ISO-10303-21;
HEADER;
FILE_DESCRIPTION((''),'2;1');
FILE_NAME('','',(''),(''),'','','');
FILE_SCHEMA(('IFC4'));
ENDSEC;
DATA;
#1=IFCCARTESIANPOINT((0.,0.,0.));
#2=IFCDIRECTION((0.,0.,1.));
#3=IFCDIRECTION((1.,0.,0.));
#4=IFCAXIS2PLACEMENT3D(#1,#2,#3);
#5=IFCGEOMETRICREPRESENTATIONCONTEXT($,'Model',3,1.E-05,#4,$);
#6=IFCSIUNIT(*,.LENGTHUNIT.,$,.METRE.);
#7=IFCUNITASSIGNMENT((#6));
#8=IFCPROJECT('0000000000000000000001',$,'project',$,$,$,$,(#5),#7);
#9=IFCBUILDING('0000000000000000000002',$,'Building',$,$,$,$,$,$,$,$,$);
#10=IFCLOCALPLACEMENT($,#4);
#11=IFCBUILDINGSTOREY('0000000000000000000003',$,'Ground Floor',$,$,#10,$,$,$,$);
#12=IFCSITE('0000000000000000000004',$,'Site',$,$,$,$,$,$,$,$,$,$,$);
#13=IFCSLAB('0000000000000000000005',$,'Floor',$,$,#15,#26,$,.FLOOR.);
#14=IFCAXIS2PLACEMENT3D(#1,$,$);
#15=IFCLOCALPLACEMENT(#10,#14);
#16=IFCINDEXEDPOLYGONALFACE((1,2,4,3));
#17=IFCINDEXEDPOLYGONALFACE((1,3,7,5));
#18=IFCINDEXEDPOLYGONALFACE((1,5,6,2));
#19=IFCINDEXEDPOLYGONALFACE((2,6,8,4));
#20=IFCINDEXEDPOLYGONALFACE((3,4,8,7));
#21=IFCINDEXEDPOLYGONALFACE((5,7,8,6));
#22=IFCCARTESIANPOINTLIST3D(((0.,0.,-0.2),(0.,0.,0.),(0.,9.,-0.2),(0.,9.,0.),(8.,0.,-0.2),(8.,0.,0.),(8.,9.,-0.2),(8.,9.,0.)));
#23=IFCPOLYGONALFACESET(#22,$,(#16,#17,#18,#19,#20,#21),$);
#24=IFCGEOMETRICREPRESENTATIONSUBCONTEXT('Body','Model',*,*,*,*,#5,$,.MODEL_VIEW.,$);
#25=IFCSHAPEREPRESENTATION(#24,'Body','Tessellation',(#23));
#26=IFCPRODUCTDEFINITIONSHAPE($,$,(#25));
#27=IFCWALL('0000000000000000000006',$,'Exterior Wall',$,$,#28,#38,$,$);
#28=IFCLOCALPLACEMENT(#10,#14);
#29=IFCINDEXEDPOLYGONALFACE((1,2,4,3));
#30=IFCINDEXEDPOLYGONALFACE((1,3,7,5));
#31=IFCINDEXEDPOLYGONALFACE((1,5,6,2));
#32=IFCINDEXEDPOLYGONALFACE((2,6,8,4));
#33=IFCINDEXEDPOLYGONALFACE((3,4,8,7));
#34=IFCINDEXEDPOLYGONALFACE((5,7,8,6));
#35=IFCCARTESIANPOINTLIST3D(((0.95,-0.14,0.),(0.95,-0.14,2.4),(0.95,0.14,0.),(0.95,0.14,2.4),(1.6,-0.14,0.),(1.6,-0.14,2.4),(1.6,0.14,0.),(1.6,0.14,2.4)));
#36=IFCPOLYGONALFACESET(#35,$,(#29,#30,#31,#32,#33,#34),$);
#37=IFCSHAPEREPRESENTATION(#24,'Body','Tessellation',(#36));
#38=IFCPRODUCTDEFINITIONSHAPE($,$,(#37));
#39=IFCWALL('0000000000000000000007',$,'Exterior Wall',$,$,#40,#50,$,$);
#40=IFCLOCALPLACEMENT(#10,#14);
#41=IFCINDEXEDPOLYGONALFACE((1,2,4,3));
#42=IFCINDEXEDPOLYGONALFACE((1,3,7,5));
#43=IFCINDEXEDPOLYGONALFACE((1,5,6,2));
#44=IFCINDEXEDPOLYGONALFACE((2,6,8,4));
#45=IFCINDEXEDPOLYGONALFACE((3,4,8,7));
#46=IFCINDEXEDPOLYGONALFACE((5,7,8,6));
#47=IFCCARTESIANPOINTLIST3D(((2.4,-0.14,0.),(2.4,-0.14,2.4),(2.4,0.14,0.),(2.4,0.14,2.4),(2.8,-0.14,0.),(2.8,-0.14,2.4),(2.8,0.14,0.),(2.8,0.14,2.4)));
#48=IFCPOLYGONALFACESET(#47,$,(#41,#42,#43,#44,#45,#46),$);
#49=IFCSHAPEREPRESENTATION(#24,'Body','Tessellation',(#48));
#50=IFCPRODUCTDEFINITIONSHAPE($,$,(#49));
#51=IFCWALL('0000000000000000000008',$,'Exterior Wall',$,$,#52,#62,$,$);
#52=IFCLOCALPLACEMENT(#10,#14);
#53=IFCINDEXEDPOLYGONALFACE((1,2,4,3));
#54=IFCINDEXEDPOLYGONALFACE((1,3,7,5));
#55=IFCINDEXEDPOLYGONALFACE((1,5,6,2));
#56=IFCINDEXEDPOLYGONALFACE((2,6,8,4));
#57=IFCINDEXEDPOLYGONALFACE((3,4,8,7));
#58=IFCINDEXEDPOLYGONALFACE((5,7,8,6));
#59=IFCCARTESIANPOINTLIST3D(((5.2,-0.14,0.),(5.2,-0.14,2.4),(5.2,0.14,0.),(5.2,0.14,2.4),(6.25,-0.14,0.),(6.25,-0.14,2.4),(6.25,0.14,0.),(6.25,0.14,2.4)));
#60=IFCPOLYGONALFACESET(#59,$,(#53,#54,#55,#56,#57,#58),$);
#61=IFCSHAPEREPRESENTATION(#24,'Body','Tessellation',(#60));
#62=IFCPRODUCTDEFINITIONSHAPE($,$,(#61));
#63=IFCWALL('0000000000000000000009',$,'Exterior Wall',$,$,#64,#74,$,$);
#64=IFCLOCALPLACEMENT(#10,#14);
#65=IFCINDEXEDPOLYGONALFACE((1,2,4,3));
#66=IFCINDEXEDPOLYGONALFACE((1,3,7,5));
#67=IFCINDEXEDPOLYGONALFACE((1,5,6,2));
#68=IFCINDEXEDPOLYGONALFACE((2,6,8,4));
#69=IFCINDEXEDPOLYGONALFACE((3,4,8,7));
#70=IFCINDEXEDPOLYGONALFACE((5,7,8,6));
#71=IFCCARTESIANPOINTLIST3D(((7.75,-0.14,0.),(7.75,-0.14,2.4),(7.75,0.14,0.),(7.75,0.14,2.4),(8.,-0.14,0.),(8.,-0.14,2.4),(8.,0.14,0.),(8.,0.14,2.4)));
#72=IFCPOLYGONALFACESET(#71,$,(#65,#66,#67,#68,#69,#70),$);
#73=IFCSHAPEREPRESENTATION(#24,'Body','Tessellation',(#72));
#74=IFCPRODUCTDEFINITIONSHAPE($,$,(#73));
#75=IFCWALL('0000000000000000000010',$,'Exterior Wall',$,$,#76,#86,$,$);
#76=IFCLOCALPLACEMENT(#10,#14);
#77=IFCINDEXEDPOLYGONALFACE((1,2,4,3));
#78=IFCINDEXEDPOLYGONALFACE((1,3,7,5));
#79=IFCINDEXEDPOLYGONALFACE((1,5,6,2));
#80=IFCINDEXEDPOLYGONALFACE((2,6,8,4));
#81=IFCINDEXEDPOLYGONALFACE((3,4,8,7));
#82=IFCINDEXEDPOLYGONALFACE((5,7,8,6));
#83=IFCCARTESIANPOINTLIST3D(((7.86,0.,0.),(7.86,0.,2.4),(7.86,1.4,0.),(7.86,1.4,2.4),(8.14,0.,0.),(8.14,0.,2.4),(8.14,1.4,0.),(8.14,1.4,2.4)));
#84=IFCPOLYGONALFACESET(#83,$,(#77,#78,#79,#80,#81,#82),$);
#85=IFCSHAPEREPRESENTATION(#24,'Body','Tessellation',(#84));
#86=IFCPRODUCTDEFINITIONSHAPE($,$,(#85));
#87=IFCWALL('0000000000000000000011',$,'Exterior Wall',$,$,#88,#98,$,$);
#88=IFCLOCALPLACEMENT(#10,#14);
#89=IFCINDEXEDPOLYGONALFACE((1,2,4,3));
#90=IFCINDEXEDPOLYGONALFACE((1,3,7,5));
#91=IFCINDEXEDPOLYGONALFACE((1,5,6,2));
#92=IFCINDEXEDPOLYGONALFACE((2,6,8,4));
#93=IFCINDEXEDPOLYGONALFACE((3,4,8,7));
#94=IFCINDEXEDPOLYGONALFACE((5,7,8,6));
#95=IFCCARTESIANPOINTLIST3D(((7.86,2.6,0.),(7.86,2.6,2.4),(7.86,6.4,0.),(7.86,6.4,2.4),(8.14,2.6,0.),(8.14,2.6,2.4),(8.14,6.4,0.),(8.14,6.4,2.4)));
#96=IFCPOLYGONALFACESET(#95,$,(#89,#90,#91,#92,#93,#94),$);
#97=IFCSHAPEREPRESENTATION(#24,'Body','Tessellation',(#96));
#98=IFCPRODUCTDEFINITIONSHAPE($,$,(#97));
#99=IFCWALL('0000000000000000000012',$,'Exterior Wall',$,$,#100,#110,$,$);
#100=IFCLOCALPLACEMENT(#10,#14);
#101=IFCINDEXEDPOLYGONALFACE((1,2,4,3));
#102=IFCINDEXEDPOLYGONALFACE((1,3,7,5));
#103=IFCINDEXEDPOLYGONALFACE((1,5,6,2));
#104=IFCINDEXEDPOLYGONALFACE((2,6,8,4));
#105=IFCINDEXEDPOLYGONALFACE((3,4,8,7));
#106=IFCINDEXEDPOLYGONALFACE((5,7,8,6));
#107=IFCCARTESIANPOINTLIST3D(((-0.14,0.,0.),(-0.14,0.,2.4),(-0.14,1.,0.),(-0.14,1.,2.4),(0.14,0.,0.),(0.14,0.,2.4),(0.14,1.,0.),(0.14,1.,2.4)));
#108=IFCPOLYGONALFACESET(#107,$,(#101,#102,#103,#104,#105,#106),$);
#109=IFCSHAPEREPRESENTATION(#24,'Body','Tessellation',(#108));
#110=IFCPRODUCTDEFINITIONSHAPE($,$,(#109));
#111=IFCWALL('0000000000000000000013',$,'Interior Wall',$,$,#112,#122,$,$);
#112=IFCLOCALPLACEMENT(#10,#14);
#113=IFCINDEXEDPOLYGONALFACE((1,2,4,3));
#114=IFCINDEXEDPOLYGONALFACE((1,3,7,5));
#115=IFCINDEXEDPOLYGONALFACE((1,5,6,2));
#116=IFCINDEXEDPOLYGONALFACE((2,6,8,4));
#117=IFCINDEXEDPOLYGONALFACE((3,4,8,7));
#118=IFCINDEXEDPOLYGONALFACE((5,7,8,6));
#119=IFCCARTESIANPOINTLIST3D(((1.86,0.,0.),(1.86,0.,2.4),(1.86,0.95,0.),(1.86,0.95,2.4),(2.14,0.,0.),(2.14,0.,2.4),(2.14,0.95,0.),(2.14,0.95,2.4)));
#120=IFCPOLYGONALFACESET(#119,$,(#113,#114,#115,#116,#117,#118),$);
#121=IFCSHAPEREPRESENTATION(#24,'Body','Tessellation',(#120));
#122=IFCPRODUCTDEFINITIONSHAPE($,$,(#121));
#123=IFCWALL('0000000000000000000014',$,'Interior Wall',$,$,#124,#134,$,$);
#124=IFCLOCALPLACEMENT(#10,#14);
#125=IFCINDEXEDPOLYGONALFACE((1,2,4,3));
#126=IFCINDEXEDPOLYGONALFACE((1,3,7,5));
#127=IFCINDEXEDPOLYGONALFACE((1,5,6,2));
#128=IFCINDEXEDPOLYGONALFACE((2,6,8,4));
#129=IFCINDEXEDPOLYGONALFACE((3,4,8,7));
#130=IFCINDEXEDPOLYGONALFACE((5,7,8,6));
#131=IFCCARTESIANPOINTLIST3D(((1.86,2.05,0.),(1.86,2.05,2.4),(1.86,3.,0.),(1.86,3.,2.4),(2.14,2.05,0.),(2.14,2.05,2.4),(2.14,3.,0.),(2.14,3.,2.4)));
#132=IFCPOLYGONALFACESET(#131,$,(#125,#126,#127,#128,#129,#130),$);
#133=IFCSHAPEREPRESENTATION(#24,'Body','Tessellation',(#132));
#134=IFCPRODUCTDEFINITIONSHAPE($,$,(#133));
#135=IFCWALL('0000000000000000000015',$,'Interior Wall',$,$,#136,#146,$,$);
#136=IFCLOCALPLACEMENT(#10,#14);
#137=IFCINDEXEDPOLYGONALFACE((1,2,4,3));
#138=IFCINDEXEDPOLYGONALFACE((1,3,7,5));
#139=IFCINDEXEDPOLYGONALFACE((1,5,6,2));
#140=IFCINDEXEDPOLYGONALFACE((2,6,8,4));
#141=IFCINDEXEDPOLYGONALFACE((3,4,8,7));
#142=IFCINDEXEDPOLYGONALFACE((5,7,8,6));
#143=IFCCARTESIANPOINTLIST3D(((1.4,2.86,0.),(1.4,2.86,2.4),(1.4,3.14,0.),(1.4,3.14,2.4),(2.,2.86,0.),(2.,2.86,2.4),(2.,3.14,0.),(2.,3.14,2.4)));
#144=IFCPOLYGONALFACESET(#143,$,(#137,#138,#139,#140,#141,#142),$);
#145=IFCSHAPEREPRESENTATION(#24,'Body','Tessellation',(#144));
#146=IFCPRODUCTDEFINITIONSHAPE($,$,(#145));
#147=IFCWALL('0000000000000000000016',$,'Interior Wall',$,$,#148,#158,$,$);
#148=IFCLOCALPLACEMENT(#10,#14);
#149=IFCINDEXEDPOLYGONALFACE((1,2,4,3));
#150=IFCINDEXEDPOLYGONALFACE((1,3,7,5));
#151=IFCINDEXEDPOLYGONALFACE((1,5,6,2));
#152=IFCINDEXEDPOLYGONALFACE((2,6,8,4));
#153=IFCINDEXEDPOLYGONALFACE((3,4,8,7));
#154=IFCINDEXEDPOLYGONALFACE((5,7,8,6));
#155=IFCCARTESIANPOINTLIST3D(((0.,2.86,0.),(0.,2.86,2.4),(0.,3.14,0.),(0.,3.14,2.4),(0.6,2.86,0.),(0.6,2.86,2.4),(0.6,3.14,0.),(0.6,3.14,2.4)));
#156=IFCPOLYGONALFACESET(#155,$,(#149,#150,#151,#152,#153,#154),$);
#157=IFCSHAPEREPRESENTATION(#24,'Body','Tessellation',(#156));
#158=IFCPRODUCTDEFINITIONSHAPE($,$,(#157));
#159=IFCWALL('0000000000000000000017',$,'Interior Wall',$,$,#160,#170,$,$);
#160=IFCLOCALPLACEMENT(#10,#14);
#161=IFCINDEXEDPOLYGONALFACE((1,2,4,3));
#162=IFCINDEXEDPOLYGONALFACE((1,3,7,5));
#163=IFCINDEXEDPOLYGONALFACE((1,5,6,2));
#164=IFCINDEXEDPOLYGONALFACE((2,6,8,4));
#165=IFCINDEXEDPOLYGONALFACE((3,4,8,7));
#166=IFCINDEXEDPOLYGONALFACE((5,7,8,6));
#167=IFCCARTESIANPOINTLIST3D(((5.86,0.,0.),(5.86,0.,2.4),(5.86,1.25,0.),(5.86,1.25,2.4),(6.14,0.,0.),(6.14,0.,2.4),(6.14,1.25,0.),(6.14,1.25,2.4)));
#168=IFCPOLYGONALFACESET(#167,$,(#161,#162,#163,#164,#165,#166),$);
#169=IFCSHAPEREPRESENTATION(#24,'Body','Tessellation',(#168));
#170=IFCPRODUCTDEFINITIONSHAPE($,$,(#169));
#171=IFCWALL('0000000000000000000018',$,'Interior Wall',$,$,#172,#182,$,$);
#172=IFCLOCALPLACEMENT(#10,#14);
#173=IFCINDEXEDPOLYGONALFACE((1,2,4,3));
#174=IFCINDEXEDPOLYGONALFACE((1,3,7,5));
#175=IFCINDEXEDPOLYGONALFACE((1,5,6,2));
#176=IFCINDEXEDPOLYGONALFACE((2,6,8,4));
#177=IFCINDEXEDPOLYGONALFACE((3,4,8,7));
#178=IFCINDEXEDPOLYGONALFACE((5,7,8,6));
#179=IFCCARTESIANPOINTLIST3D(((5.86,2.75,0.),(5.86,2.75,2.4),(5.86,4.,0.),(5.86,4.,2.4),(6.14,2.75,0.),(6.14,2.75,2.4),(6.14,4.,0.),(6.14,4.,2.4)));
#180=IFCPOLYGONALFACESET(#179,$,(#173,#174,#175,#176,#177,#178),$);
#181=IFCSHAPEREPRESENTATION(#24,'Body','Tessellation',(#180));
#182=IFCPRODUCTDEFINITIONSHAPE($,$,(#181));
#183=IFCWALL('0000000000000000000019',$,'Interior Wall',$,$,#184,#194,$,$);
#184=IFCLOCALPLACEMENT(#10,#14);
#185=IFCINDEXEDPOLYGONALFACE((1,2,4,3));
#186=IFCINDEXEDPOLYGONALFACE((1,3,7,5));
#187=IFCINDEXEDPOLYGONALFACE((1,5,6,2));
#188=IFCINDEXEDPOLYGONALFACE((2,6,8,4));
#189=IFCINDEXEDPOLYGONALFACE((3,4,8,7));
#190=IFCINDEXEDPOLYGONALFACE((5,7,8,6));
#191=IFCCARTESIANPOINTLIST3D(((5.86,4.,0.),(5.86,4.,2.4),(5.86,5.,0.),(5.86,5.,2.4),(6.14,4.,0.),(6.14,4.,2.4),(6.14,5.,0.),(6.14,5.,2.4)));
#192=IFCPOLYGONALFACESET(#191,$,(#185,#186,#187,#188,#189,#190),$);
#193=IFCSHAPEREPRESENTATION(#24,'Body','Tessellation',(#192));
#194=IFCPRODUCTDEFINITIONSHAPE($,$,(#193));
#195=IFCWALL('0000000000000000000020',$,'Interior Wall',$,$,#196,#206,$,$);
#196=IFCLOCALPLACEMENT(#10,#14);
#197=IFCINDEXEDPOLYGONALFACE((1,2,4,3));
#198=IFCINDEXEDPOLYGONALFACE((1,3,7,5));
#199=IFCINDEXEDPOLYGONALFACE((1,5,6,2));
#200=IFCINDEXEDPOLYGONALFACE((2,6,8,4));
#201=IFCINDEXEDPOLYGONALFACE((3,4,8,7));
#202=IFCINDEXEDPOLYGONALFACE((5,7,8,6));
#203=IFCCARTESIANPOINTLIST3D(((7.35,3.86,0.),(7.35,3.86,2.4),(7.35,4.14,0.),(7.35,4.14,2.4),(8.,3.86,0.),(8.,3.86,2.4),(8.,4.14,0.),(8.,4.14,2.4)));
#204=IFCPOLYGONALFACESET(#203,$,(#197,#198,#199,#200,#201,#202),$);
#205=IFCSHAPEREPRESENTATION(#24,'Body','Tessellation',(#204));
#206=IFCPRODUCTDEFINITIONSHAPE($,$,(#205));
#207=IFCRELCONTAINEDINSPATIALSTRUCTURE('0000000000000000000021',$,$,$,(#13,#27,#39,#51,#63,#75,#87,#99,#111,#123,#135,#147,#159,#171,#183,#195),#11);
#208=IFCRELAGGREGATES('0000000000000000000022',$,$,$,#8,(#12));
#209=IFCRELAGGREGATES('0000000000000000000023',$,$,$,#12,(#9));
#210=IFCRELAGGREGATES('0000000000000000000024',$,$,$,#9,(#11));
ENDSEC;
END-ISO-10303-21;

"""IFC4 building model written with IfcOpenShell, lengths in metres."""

from ifc_helpers import new_model, si_unit, frame, origin_with_axes, place, context, subcontext, project, spatial, indexed_curve, outline, extrude, element, save


model = new_model("IFC4")

# Units and contexts
model_context = context("Model", 3, precision=1e-05, world=origin_with_axes())
body_context = subcontext(model_context, "Body", "Model", "MODEL_VIEW")
ifc_project = project(units=[si_unit("LENGTHUNIT", "METRE")], contexts=[model_context])

# Site, building, storey
site = spatial("IfcSite", under=ifc_project, Name="Site")
building = spatial("IfcBuilding", under=site, Name="Building")
storey_placement = place(None, origin_with_axes())
storey = spatial("IfcBuildingStorey", under=building, at=storey_placement, Name="Ground Floor")

# Slab
slab_placement = place(storey_placement, frame((0.0, 0.0, -0.2), z_axis=(0.0, 0.0, 1.0), x_axis=(1.0, 0.0, 0.0)))
element("IfcSlab", 1, at=slab_placement, inside=storey, Name="Floor", PredefinedType="FLOOR", context=body_context, shape_type="SweptSolid", body=[
    extrude(outline(indexed_curve([(0.0, 0.0), (8.0, 0.0), (8.0, 9.0), (0.0, 9.0)])), None, (0.0, 0.0, 1.0), 0.2),
])

# Walls
wall_1_placement = place(storey_placement, frame((0.95, 0.0, 0.0), z_axis=(0.0, 0.0, 1.0), x_axis=(1.0, 0.0, 0.0)))
element("IfcWall", 2, at=wall_1_placement, inside=storey, Name="Exterior Wall", context=body_context, shape_type="SweptSolid", body=[
    extrude(outline(indexed_curve([(0.0, 0.0), (0.0, 0.28), (0.65, 0.28), (0.65, 0.0), (0.0, 0.0)], self_intersect=False)), frame((0.0, -0.14, 0.0), z_axis=(0.0, 0.0, 1.0), x_axis=(1.0, 0.0, 0.0)), (0.0, 0.0, 1.0), 2.4),
])
wall_2_placement = place(storey_placement, frame((2.4, 0.0, 0.0), z_axis=(0.0, 0.0, 1.0), x_axis=(1.0, 0.0, 0.0)))
element("IfcWall", 3, at=wall_2_placement, inside=storey, Name="Exterior Wall", context=body_context, shape_type="SweptSolid", body=[
    extrude(outline(indexed_curve([(0.0, 0.0), (0.0, 0.28), (0.4, 0.28), (0.4, 0.0), (0.0, 0.0)], self_intersect=False)), frame((0.0, -0.14, 0.0), z_axis=(0.0, 0.0, 1.0), x_axis=(1.0, 0.0, 0.0)), (0.0, 0.0, 1.0), 2.4),
])
wall_3_placement = place(storey_placement, frame((5.2, 0.0, 0.0), z_axis=(0.0, 0.0, 1.0), x_axis=(1.0, 0.0, 0.0)))
element("IfcWall", 4, at=wall_3_placement, inside=storey, Name="Exterior Wall", context=body_context, shape_type="SweptSolid", body=[
    extrude(outline(indexed_curve([(0.0, 0.0), (0.0, 0.28), (1.05, 0.28), (1.05, 0.0), (0.0, 0.0)], self_intersect=False)), frame((0.0, -0.14, 0.0), z_axis=(0.0, 0.0, 1.0), x_axis=(1.0, 0.0, 0.0)), (0.0, 0.0, 1.0), 2.4),
])
wall_4_placement = place(storey_placement, frame((7.75, 0.0, 0.0), z_axis=(0.0, 0.0, 1.0), x_axis=(1.0, 0.0, 0.0)))
element("IfcWall", 5, at=wall_4_placement, inside=storey, Name="Exterior Wall", context=body_context, shape_type="SweptSolid", body=[
    extrude(outline(indexed_curve([(0.0, 0.0), (0.0, 0.28), (0.25, 0.28), (0.25, 0.0), (0.0, 0.0)], self_intersect=False)), frame((0.0, -0.14, 0.0), z_axis=(0.0, 0.0, 1.0), x_axis=(1.0, 0.0, 0.0)), (0.0, 0.0, 1.0), 2.4),
])
wall_5_placement = place(storey_placement, frame((8.0, 0.0, 0.0), z_axis=(0.0, 0.0, 1.0), x_axis=(0.0, 1.0, 0.0)))
element("IfcWall", 6, at=wall_5_placement, inside=storey, Name="Exterior Wall", context=body_context, shape_type="SweptSolid", body=[
    extrude(outline(indexed_curve([(0.0, 0.0), (0.0, 0.28), (1.4, 0.28), (1.4, 0.0), (0.0, 0.0)], self_intersect=False)), frame((0.0, -0.14, 0.0), z_axis=(0.0, 0.0, 1.0), x_axis=(1.0, 0.0, 0.0)), (0.0, 0.0, 1.0), 2.4),
])
wall_6_placement = place(storey_placement, frame((8.0, 2.6, 0.0), z_axis=(0.0, 0.0, 1.0), x_axis=(0.0, 1.0, 0.0)))
element("IfcWall", 7, at=wall_6_placement, inside=storey, Name="Exterior Wall", context=body_context, shape_type="SweptSolid", body=[
    extrude(outline(indexed_curve([(0.0, 0.0), (0.0, 0.28), (3.8, 0.28), (3.8, 0.0), (0.0, 0.0)], self_intersect=False)), frame((0.0, -0.14, 0.0), z_axis=(0.0, 0.0, 1.0), x_axis=(1.0, 0.0, 0.0)), (0.0, 0.0, 1.0), 2.4),
])
wall_7_placement = place(storey_placement, frame((0.0, 1.0, 0.0), z_axis=(0.0, 0.0, 1.0), x_axis=(0.0, -1.0, 0.0)))
element("IfcWall", 8, at=wall_7_placement, inside=storey, Name="Exterior Wall", context=body_context, shape_type="SweptSolid", body=[
    extrude(outline(indexed_curve([(0.0, 0.0), (0.0, 0.28), (1.0, 0.28), (1.0, 0.0), (0.0, 0.0)], self_intersect=False)), frame((0.0, -0.14, 0.0), z_axis=(0.0, 0.0, 1.0), x_axis=(1.0, 0.0, 0.0)), (0.0, 0.0, 1.0), 2.4),
])
wall_8_placement = place(storey_placement, frame((2.0, 0.0, 0.0), z_axis=(0.0, 0.0, 1.0), x_axis=(0.0, 1.0, 0.0)))
element("IfcWall", 9, at=wall_8_placement, inside=storey, Name="Interior Wall", context=body_context, shape_type="SweptSolid", body=[
    extrude(outline(indexed_curve([(0.0, 0.0), (0.0, 0.28), (0.95, 0.28), (0.95, 0.0), (0.0, 0.0)], self_intersect=False)), frame((0.0, -0.14, 0.0), z_axis=(0.0, 0.0, 1.0), x_axis=(1.0, 0.0, 0.0)), (0.0, 0.0, 1.0), 2.4),
])
wall_9_placement = place(storey_placement, frame((2.0, 2.05, 0.0), z_axis=(0.0, 0.0, 1.0), x_axis=(0.0, 1.0, 0.0)))
element("IfcWall", 10, at=wall_9_placement, inside=storey, Name="Interior Wall", context=body_context, shape_type="SweptSolid", body=[
    extrude(outline(indexed_curve([(0.0, 0.0), (0.0, 0.28), (0.95, 0.28), (0.95, 0.0), (0.0, 0.0)], self_intersect=False)), frame((0.0, -0.14, 0.0), z_axis=(0.0, 0.0, 1.0), x_axis=(1.0, 0.0, 0.0)), (0.0, 0.0, 1.0), 2.4),
])
for number, where, z_axis, x_axis, name in (
    (11, (2.0, 3.0, 0.0), (0.0, 0.0, 1.0), (-1.0, 0.0, 0.0), "Interior Wall"),
    (12, (0.6, 3.0, 0.0), (0.0, 0.0, 1.0), (-1.0, 0.0, 0.0), "Interior Wall"),
):
    element("IfcWall", number, at=place(storey_placement, frame(where, z_axis=z_axis, x_axis=x_axis)), inside=storey, Name=name, context=body_context, shape_type="SweptSolid", body=[
        extrude(outline(indexed_curve([(0.0, 0.0), (0.0, 0.28), (0.6, 0.28), (0.6, 0.0), (0.0, 0.0)], self_intersect=False)), frame((0.0, -0.14, 0.0), z_axis=(0.0, 0.0, 1.0), x_axis=(1.0, 0.0, 0.0)), (0.0, 0.0, 1.0), 2.4),
    ])
for number, where, z_axis, x_axis, name in (
    (13, (6.0, 0.0, 0.0), (0.0, 0.0, 1.0), (0.0, 1.0, 0.0), "Interior Wall"),
    (14, (6.0, 2.75, 0.0), (0.0, 0.0, 1.0), (0.0, 1.0, 0.0), "Interior Wall"),
):
    element("IfcWall", number, at=place(storey_placement, frame(where, z_axis=z_axis, x_axis=x_axis)), inside=storey, Name=name, context=body_context, shape_type="SweptSolid", body=[
        extrude(outline(indexed_curve([(0.0, 0.0), (0.0, 0.28), (1.25, 0.28), (1.25, 0.0), (0.0, 0.0)], self_intersect=False)), frame((0.0, -0.14, 0.0), z_axis=(0.0, 0.0, 1.0), x_axis=(1.0, 0.0, 0.0)), (0.0, 0.0, 1.0), 2.4),
    ])
wall_10_placement = place(storey_placement, frame((6.0, 4.0, 0.0), z_axis=(0.0, 0.0, 1.0), x_axis=(0.0, 1.0, 0.0)))
element("IfcWall", 15, at=wall_10_placement, inside=storey, Name="Interior Wall", context=body_context, shape_type="SweptSolid", body=[
    extrude(outline(indexed_curve([(0.0, 0.0), (0.0, 0.28), (1.0, 0.28), (1.0, 0.0), (0.0, 0.0)], self_intersect=False)), frame((0.0, -0.14, 0.0), z_axis=(0.0, 0.0, 1.0), x_axis=(1.0, 0.0, 0.0)), (0.0, 0.0, 1.0), 2.4),
])
for number, where, z_axis, x_axis, name in (
    (16, (8.0, 4.0, 0.0), (0.0, 0.0, 1.0), (-1.0, 0.0, 0.0), "Interior Wall"),
):
    element("IfcWall", number, at=place(storey_placement, frame(where, z_axis=z_axis, x_axis=x_axis)), inside=storey, Name=name, context=body_context, shape_type="SweptSolid", body=[
        extrude(outline(indexed_curve([(0.0, 0.0), (0.0, 0.28), (0.65, 0.28), (0.65, 0.0), (0.0, 0.0)], self_intersect=False)), frame((0.0, -0.14, 0.0), z_axis=(0.0, 0.0, 1.0), x_axis=(1.0, 0.0, 0.0)), (0.0, 0.0, 1.0), 2.4),
    ])

save(model, "model.ifc")
